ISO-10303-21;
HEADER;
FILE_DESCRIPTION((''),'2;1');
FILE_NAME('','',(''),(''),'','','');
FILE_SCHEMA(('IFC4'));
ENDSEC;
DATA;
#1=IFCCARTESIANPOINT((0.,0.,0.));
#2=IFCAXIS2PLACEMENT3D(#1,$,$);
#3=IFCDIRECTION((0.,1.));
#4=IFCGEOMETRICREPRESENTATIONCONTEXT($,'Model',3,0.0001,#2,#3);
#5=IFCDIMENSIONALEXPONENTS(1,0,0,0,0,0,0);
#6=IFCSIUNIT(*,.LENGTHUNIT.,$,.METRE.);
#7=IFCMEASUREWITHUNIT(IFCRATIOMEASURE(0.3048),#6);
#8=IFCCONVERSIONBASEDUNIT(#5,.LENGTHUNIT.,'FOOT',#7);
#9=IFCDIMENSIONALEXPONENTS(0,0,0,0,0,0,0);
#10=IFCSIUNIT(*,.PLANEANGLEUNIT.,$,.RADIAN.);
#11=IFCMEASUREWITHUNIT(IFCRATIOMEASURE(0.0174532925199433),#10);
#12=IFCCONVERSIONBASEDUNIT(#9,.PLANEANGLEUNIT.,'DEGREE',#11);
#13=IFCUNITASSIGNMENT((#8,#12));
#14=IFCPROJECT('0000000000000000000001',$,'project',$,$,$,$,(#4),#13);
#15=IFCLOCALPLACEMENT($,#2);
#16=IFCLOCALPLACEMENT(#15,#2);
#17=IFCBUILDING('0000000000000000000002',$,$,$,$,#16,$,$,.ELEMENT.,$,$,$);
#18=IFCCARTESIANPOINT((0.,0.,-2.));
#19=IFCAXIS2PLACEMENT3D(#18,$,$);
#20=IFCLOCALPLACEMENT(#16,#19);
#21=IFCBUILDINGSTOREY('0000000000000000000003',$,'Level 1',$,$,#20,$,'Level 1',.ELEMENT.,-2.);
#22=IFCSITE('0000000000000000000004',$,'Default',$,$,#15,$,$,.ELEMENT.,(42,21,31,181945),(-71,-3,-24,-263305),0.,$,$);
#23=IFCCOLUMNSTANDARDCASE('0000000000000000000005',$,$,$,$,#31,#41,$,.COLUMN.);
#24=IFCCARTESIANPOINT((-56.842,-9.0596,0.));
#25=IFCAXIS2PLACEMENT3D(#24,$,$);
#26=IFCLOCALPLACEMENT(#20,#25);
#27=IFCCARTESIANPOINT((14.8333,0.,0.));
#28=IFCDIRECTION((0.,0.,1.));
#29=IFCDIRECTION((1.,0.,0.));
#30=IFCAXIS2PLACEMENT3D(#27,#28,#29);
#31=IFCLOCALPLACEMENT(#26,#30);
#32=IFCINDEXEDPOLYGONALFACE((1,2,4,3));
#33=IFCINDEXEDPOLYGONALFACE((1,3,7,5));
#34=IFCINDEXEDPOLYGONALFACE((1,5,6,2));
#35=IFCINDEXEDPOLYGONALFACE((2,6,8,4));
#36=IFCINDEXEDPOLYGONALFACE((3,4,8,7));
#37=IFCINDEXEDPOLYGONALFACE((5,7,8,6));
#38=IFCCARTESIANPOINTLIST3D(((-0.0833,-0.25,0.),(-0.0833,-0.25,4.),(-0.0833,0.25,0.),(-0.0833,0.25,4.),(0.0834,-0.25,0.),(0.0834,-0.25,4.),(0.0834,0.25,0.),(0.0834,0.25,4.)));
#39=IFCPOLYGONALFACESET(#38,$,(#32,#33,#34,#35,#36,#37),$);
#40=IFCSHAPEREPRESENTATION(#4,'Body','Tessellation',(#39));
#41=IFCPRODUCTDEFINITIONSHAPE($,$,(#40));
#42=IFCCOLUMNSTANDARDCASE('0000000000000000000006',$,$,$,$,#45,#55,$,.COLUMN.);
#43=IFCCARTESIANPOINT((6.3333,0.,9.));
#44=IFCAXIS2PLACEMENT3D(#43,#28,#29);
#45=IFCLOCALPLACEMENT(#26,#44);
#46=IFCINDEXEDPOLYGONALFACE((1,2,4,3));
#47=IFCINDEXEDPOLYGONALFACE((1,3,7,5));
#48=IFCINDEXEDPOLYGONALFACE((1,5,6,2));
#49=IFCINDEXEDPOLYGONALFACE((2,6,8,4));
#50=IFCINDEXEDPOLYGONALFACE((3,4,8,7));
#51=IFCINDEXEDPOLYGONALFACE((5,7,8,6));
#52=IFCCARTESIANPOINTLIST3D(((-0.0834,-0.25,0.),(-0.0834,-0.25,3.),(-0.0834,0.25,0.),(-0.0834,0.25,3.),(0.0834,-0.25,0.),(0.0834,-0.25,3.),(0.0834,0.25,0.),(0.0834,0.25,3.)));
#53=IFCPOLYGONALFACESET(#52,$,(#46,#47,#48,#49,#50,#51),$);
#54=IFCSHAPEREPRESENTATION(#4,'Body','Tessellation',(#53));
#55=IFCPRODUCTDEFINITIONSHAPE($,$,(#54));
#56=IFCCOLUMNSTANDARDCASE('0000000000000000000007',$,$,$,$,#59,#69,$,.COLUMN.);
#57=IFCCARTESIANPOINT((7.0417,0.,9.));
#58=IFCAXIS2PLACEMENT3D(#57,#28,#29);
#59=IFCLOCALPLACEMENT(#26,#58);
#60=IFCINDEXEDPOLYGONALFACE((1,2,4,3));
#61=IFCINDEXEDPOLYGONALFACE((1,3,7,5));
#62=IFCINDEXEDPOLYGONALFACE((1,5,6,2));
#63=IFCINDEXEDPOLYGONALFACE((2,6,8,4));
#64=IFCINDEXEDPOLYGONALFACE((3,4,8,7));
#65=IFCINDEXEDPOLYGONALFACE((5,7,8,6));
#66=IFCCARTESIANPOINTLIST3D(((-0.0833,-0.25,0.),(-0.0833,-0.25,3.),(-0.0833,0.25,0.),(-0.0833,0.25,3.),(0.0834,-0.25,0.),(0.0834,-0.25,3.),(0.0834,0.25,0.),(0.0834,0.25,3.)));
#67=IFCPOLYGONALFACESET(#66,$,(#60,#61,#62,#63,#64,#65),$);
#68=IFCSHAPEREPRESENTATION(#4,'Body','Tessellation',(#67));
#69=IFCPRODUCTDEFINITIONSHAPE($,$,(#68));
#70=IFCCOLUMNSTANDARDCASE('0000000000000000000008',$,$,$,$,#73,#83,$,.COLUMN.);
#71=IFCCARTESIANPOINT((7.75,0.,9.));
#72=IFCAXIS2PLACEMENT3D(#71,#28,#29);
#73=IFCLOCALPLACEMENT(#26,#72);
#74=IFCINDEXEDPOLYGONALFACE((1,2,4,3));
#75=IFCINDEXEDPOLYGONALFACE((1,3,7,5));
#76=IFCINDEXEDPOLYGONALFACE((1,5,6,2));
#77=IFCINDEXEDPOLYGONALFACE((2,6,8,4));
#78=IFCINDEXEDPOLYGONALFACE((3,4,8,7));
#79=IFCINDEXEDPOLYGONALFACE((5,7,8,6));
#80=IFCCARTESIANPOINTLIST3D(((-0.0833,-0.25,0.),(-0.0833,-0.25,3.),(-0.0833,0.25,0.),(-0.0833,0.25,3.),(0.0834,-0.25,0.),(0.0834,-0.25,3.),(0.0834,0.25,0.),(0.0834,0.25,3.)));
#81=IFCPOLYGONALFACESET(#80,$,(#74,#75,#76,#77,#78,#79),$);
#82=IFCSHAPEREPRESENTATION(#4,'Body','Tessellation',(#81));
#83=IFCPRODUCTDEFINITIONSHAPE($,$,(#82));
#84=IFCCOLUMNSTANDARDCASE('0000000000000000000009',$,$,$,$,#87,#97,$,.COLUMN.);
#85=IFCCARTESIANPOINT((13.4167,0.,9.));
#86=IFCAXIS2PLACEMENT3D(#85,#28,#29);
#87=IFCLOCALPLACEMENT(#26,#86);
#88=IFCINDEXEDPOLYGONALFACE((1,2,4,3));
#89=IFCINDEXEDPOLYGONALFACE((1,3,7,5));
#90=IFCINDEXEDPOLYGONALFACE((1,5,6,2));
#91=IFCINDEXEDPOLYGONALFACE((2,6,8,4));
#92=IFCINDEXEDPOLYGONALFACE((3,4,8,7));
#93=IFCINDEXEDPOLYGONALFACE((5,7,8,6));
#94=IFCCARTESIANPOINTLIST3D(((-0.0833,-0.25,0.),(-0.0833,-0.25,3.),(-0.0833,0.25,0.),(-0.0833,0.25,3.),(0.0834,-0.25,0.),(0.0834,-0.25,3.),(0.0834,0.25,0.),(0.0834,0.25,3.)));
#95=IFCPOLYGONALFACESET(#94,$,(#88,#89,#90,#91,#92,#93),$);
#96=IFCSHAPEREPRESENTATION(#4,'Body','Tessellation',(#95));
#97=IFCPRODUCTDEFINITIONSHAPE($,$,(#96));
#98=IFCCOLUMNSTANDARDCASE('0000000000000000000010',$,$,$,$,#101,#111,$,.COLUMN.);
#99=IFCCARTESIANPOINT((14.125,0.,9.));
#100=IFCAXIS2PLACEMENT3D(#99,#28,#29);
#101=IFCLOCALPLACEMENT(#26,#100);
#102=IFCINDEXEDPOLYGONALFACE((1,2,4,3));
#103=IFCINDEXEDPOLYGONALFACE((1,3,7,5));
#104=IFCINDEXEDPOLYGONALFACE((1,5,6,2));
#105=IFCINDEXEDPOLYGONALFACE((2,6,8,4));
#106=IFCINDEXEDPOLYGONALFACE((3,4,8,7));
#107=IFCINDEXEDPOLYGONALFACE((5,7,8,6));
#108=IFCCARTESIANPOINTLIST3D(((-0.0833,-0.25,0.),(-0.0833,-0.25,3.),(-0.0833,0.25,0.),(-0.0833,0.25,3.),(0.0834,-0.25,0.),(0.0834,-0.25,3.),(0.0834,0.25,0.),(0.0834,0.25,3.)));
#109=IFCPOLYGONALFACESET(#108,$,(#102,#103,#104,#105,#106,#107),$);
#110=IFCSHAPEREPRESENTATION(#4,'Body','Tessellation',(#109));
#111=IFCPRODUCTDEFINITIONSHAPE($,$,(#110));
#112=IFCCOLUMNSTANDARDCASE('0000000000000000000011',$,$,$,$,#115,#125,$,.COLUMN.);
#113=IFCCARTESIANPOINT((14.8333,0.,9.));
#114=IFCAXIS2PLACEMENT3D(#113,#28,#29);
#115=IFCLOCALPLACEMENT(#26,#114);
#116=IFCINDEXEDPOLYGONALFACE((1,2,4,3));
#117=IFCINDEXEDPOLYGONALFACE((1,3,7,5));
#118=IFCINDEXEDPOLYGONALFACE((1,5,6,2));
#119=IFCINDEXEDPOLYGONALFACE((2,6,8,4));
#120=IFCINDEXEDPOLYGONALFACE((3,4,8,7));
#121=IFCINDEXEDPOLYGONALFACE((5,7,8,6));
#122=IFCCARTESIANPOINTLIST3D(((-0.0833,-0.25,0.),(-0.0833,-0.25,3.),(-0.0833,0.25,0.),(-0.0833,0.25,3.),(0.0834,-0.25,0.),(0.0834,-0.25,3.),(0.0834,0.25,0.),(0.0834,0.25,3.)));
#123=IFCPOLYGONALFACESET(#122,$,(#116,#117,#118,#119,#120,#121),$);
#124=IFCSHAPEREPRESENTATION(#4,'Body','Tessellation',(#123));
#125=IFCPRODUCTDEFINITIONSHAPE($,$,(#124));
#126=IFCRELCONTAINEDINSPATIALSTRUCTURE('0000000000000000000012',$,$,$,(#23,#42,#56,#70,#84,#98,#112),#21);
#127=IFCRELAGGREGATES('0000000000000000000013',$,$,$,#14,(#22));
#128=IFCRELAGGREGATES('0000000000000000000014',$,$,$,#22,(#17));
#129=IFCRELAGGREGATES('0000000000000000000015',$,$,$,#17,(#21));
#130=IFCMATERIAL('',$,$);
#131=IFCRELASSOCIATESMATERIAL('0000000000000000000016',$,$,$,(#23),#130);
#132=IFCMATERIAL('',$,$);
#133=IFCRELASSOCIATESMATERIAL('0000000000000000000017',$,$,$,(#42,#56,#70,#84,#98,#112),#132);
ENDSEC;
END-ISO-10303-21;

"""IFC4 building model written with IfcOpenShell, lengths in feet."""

from ifc_helpers import new_model, entity, si_unit, converted_unit, direction, frame, origin, place, context, project, spatial, rectangle, extrude, material, element, save


model = new_model("IFC4")

# Units and contexts
model_context = context("Model", 3, precision=0.0001, world=origin(), true_north=direction((0.0, 1.0)))
ifc_project = project(units=[converted_unit("LENGTHUNIT", "FOOT", entity("IfcRatioMeasure", 0.3048), si_unit("LENGTHUNIT", "METRE"), dimensions=[1, 0, 0, 0, 0, 0, 0]), converted_unit("PLANEANGLEUNIT", "DEGREE", entity("IfcRatioMeasure", 0.0174532925199433), si_unit("PLANEANGLEUNIT", "RADIAN"), dimensions=[0, 0, 0, 0, 0, 0, 0])], contexts=[model_context])

# Site, building, storey
site_placement = place(None, origin())
site = spatial("IfcSite", under=ifc_project, at=site_placement, Name="Default", CompositionType="ELEMENT", RefLatitude=(42, 21, 31, 181945), RefLongitude=(-71, -3, -24, -263305), RefElevation=0.0)
building_placement = place(site_placement, origin())
building = spatial("IfcBuilding", under=site, at=building_placement, CompositionType="ELEMENT")
storey_placement = place(building_placement, frame((0.0, 0.0, -2.0)))
storey = spatial("IfcBuildingStorey", under=building, at=storey_placement, Name="Level 1", LongName="Level 1", CompositionType="ELEMENT", Elevation=-2.0)

# Columns
ifc_material_1 = material(Name="")
placement = place(storey_placement, frame((-56.842, -9.0596, 0.0)))
for number, where, z_axis, x_axis in (
    (1, (14.8333, 0.0, 0.0), (0.0, 0.0, 1.0), (1.0, 0.0, 0.0)),
):
    element("IfcColumnStandardCase", number, at=place(placement, frame(where, z_axis=z_axis, x_axis=x_axis)), inside=storey, material=ifc_material_1, PredefinedType="COLUMN", context=model_context, shape_type="SweptSolid", body=[
        extrude(rectangle(XDim=0.1667, YDim=0.5), origin(), (0.0, 0.0, 1.0), 4.0),
    ])
ifc_material_2 = material(Name="")
for number, where, z_axis, x_axis in (
    (2, (6.3333, 0.0, 9.0), (0.0, 0.0, 1.0), (1.0, 0.0, 0.0)),
    (3, (7.0417, 0.0, 9.0), (0.0, 0.0, 1.0), (1.0, 0.0, 0.0)),
    (4, (7.75, 0.0, 9.0), (0.0, 0.0, 1.0), (1.0, 0.0, 0.0)),
    (5, (13.4167, 0.0, 9.0), (0.0, 0.0, 1.0), (1.0, 0.0, 0.0)),
    (6, (14.125, 0.0, 9.0), (0.0, 0.0, 1.0), (1.0, 0.0, 0.0)),
    (7, (14.8333, 0.0, 9.0), (0.0, 0.0, 1.0), (1.0, 0.0, 0.0)),
):
    element("IfcColumnStandardCase", number, at=place(placement, frame(where, z_axis=z_axis, x_axis=x_axis)), inside=storey, material=ifc_material_2, PredefinedType="COLUMN", context=model_context, shape_type="SweptSolid", body=[
        extrude(rectangle(XDim=0.1667, YDim=0.5), origin(), (0.0, 0.0, 1.0), 3.0),
    ])

save(model, "model.ifc")
